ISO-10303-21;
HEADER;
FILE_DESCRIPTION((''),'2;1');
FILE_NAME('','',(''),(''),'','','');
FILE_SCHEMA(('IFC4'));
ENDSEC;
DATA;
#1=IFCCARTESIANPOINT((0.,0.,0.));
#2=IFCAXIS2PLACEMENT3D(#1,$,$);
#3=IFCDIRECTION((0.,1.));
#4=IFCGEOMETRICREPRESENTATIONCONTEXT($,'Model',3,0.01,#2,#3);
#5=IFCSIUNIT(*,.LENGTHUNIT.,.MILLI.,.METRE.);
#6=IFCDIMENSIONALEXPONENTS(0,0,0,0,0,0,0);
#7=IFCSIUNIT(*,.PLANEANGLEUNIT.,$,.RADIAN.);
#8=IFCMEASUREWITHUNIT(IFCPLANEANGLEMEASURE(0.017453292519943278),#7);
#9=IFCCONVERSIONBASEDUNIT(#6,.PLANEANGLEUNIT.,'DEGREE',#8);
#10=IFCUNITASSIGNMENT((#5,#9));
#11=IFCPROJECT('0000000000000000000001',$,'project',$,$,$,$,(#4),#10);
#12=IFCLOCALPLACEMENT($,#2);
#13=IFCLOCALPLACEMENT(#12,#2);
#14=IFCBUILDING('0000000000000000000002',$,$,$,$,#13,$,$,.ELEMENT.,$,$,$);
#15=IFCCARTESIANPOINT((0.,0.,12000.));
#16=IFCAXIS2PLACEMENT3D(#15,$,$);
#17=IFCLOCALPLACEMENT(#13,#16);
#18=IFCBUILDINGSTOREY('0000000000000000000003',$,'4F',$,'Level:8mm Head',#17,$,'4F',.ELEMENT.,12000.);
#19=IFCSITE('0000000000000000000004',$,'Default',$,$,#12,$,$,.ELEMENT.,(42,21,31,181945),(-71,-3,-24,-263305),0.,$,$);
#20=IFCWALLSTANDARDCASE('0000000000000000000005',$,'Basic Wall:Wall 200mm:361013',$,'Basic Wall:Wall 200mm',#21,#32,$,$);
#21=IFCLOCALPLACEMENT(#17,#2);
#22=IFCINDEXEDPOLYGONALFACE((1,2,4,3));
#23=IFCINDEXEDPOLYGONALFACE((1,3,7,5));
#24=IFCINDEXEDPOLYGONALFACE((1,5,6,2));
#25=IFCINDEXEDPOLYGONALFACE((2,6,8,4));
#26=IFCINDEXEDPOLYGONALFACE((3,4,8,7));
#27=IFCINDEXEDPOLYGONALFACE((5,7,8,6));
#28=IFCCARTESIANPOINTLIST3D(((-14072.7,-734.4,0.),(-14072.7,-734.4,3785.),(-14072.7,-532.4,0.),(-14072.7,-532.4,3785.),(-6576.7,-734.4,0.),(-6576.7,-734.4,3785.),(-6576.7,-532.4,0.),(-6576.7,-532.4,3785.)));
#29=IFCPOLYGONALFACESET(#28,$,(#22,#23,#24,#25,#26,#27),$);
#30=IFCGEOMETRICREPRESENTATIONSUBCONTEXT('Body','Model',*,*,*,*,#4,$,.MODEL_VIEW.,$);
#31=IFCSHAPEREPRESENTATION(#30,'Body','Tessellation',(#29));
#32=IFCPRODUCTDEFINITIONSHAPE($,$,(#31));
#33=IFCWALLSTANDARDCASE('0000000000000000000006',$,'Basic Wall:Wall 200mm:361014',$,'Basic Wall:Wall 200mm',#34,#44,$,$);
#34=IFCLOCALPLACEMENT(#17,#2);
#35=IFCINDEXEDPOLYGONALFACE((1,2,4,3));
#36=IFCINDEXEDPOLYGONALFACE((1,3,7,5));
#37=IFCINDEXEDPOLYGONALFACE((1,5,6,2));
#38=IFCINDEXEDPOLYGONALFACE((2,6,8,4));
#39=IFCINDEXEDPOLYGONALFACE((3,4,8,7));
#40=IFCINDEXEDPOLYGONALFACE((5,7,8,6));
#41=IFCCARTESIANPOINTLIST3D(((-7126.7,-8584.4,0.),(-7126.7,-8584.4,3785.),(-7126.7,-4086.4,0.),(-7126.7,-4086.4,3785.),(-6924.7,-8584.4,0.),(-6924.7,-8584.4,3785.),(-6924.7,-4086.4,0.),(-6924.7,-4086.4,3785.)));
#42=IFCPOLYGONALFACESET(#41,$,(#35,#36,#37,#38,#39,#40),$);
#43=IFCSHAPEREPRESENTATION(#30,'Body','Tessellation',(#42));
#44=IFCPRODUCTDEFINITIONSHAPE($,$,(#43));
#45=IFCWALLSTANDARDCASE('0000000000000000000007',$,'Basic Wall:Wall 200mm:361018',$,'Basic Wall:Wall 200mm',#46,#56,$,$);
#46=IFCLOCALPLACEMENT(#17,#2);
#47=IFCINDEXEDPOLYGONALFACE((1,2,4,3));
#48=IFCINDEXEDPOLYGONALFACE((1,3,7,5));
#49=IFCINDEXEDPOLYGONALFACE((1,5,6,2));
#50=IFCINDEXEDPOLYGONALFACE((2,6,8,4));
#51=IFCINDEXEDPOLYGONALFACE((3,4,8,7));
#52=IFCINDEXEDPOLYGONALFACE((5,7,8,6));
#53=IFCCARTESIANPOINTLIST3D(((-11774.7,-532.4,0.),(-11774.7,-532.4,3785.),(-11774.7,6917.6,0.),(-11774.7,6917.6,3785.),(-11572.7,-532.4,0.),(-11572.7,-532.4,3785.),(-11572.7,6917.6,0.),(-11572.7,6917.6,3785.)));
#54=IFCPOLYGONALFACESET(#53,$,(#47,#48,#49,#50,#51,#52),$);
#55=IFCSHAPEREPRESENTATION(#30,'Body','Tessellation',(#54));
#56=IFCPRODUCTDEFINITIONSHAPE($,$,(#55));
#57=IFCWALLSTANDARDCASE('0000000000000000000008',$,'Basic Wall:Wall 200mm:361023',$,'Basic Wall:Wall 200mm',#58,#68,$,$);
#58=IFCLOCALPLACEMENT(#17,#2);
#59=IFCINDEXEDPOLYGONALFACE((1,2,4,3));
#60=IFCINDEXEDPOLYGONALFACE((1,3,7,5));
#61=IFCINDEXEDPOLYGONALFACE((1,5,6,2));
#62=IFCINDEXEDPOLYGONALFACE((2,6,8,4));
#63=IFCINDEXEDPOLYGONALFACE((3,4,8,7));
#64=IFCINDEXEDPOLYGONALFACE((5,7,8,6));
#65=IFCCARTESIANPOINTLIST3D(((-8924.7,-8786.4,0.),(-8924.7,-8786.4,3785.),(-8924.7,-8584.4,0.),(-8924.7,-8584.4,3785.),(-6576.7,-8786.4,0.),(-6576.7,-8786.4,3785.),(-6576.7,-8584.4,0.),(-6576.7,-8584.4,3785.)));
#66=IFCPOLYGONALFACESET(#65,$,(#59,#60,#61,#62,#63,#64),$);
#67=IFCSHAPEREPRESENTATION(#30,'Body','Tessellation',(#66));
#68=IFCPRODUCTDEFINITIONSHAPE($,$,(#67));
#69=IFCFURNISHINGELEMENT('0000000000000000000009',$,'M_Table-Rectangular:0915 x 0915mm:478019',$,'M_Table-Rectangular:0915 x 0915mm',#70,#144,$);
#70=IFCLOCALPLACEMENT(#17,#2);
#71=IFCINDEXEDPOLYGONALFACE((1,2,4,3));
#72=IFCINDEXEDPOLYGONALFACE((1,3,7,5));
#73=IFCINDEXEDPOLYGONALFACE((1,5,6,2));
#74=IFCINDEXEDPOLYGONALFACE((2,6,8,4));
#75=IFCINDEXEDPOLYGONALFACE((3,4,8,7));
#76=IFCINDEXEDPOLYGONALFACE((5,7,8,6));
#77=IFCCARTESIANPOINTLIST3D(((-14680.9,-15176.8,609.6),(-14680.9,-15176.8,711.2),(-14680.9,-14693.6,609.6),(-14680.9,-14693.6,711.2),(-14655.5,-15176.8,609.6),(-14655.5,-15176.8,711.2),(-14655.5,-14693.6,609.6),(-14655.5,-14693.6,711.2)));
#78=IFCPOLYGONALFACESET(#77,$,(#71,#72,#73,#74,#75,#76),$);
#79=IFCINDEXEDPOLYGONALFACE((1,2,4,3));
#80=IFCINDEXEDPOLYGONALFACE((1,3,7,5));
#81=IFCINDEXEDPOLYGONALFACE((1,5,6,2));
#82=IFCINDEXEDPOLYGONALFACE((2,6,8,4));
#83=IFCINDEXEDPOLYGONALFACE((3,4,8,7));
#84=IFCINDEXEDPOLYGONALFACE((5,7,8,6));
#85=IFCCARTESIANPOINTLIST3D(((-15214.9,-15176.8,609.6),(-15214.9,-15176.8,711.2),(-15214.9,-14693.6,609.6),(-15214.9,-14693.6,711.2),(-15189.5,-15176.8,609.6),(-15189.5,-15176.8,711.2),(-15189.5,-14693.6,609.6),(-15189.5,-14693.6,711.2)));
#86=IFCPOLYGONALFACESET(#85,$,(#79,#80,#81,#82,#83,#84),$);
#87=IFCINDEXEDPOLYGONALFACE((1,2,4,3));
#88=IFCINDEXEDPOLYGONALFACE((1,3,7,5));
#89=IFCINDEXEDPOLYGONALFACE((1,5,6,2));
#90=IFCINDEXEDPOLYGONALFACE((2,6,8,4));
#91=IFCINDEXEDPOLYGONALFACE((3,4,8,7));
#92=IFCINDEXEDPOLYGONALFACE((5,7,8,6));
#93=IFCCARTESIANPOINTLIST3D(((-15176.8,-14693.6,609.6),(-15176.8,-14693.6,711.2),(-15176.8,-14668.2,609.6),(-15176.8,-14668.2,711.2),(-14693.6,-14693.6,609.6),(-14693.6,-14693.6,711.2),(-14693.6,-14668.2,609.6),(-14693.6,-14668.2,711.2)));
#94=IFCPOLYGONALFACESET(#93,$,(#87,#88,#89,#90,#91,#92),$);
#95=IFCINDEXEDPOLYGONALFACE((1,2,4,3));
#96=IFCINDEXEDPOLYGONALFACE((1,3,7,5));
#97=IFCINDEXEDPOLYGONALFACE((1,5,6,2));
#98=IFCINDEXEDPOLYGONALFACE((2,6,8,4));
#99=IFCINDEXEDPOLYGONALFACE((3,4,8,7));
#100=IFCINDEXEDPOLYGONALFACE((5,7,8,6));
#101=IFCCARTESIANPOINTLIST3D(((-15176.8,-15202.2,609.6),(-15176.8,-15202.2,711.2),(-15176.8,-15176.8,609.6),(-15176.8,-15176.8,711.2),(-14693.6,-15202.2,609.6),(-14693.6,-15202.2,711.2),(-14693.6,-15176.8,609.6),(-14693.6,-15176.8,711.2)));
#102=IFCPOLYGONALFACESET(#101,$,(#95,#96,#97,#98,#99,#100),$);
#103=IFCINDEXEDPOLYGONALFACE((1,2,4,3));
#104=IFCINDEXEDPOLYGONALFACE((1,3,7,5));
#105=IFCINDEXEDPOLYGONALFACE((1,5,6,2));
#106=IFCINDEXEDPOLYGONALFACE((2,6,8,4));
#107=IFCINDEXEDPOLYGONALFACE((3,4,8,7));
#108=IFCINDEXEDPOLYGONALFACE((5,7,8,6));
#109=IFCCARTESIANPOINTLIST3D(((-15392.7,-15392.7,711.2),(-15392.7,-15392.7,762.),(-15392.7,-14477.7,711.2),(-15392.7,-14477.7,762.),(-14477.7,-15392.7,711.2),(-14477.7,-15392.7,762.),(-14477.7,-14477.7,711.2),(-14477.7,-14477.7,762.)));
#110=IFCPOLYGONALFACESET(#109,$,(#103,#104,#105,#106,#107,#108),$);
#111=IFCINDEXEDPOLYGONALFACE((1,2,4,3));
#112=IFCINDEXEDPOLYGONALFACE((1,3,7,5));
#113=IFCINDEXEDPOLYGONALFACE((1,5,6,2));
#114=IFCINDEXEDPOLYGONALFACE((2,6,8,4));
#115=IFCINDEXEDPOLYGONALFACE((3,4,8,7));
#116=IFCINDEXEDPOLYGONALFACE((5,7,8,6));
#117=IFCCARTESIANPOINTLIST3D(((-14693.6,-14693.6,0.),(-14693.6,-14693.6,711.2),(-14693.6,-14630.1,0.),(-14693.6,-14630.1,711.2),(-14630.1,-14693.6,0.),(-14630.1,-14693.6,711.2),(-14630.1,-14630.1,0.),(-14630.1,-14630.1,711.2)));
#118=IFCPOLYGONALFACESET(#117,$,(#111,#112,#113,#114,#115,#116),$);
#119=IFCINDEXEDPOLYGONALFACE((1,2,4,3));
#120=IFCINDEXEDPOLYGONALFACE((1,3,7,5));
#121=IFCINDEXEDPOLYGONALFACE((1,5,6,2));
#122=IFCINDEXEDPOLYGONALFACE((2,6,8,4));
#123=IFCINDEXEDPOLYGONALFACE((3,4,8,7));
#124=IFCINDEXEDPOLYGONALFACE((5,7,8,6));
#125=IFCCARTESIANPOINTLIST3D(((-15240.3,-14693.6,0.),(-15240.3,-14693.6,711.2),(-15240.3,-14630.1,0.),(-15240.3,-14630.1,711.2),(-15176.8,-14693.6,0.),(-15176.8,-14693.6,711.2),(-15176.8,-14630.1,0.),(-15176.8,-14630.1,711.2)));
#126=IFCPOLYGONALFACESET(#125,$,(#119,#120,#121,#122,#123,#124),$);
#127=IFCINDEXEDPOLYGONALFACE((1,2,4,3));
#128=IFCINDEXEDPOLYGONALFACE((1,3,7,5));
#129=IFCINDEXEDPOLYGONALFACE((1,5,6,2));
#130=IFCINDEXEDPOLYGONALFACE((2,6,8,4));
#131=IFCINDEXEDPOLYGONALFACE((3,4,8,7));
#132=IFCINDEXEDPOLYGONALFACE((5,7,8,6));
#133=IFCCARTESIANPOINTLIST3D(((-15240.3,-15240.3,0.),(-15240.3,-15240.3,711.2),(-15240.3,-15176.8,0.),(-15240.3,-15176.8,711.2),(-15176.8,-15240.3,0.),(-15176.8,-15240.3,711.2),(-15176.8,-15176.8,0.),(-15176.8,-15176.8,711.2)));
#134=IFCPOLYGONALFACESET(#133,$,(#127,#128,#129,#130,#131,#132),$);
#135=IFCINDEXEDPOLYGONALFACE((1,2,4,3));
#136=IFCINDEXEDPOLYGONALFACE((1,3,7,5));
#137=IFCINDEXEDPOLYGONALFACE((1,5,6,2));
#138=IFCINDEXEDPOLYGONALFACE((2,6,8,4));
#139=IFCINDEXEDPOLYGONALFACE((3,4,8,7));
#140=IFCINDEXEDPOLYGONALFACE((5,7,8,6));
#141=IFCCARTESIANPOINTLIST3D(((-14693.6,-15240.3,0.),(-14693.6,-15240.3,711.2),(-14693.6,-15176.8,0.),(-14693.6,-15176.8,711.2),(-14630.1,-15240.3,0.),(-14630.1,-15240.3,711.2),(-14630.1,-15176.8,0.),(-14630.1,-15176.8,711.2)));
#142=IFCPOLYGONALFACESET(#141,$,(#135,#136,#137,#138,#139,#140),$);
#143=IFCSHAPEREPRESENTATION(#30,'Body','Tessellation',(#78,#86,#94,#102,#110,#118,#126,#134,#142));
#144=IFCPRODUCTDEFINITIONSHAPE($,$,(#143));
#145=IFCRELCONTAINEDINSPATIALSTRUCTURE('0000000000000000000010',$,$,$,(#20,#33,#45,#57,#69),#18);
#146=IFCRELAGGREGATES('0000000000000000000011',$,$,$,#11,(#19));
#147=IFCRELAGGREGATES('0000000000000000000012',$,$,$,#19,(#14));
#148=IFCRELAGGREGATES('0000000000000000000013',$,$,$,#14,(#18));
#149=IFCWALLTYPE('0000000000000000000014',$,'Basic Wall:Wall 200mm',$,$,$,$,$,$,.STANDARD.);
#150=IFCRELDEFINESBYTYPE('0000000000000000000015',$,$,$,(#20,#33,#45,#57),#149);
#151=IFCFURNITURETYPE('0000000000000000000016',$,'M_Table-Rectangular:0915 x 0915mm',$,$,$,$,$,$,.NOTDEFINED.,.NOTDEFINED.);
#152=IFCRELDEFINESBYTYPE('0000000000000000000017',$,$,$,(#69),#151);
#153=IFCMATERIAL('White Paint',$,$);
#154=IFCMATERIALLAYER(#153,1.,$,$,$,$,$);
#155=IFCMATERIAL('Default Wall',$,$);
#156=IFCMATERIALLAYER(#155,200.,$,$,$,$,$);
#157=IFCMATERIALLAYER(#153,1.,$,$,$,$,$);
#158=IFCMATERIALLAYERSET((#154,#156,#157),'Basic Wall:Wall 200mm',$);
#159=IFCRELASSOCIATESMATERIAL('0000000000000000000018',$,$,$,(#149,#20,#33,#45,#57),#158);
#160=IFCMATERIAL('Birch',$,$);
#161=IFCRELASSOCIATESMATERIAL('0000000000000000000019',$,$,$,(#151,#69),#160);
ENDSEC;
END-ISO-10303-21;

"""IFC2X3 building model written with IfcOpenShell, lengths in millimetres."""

from ifc_helpers import new_model, entity, si_unit, converted_unit, direction, frame, frame_2d, origin, origin_2d_with_axis, place, context, subcontext, project, spatial, polyline, rectangle, extrude, clip, bounded_halfspace, source, transform, mapped, material, layer, layer_set, layer_usage, type_object, type_shapes, element, save


model = new_model("IFC2X3")

# Units and contexts
model_context = context("Model", 3, precision=0.01, world=origin(), true_north=direction((0.0, 1.0)))
body_context = subcontext(model_context, "Body", "Model", "MODEL_VIEW")
ifc_project = project(units=[si_unit("LENGTHUNIT", "METRE", prefix="MILLI"), converted_unit("PLANEANGLEUNIT", "DEGREE", entity("IfcPlaneAngleMeasure", 0.017453292519943278), si_unit("PLANEANGLEUNIT", "RADIAN"), dimensions=[0, 0, 0, 0, 0, 0, 0])], contexts=[model_context])

# Site, building, storey
site_placement = place(None, origin())
site = spatial("IfcSite", under=ifc_project, at=site_placement, Name="Default", CompositionType="ELEMENT", RefLatitude=(42, 21, 31, 181945), RefLongitude=(-71, -3, -24, -263305), RefElevation=0.0)
building_placement = place(site_placement, origin())
building = spatial("IfcBuilding", under=site, at=building_placement, CompositionType="ELEMENT")
storey_placement = place(building_placement, frame((0.0, 0.0, 12000.0)))
storey = spatial("IfcBuildingStorey", under=building, at=storey_placement, Name="4F", ObjectType="Level:8mm Head", LongName="4F", CompositionType="ELEMENT", Elevation=12000.0)

# Walls
ifc_material_1 = material(Name="White Paint")
ifc_layer_1 = layer(ifc_material_1, 1.0)
ifc_material_2 = material(Name="Default Wall")
ifc_layer_2 = layer(ifc_material_2, 200.0)
ifc_layer_3 = layer(ifc_material_1, 1.0)
ifc_layer_set = layer_set([ifc_layer_1, ifc_layer_2, ifc_layer_3], Name="Basic Wall:Wall 200mm")
wall_type = type_object("IfcWallType", Name="Basic Wall:Wall 200mm", PredefinedType="STANDARD", material=ifc_layer_set)
ifc_layer_usage_1 = layer_usage(ifc_layer_set, "AXIS2", "NEGATIVE", 101.0)
wall_1_placement = place(storey_placement, frame((-14072.7, -633.4, 0.0)))
element("IfcWallStandardCase", 1, at=wall_1_placement, inside=storey, type_object=wall_type, material=ifc_layer_usage_1, Name="Basic Wall:Wall 200mm:361013", ObjectType="Basic Wall:Wall 200mm", context=body_context, shape_type="Clipping", body=[
    clip(extrude(rectangle(XDim=7496.0, YDim=202.0, at=frame_2d((3748.0, 0.0), x_axis=(-1.0, 0.0))), origin(), (0.0, 0.0, 1.0), 3785.0), bounded_halfspace(frame((0.0, -101.0, 3785.0), z_axis=(0.0, 0.0, -1.0), x_axis=(0.0, -1.0, 0.0)), True, frame((0.0, -101.0, 3785.0), z_axis=(0.0, 0.0, -1.0), x_axis=(0.0, -1.0, 0.0)), polyline([(0.0, 0.0), (-202.0, 0.0), (-202.0, -498.0), (-202.0, -2298.0), (-202.0, -2500.0), (-202.0, -6998.0), (-202.0, -7496.0), (0.0, -7496.0), (0.0, -6998.0), (0.0, -498.0), (0.0, 0.0)]))),
])
ifc_layer_usage_2 = layer_usage(ifc_layer_set, "AXIS2", "NEGATIVE", 101.0)
wall_2_placement = place(storey_placement, frame((-7025.7, -4086.4, 0.0), z_axis=(0.0, 0.0, 1.0), x_axis=(0.0, -1.0, 0.0)))
element("IfcWallStandardCase", 2, at=wall_2_placement, inside=storey, type_object=wall_type, material=ifc_layer_usage_2, Name="Basic Wall:Wall 200mm:361014", ObjectType="Basic Wall:Wall 200mm", context=body_context, shape_type="Clipping", body=[
    clip(extrude(rectangle(XDim=4498.0, YDim=202.0, at=frame_2d((2249.0, 0.0), x_axis=(-1.0, 0.0))), origin(), (0.0, 0.0, 1.0), 3785.0), bounded_halfspace(frame((0.0, -101.0, 3785.0), z_axis=(0.0, 0.0, -1.0), x_axis=(1.0, 0.0, 0.0)), True, frame((0.0, -101.0, 3785.0), z_axis=(0.0, 0.0, -1.0), x_axis=(1.0, 0.0, 0.0)), polyline([(0.0, 0.0), (0.0, -202.0), (4498.0, -202.0), (4498.0, 0.0), (4200.0, 0.0), (3998.0, 0.0), (2100.0, 0.0), (1898.0, 0.0), (0.0, 0.0)]))),
])
ifc_layer_usage_3 = layer_usage(ifc_layer_set, "AXIS2", "NEGATIVE", 101.0)
wall_3_placement = place(storey_placement, frame((-11673.7, -532.4, 0.0), z_axis=(0.0, 0.0, 1.0), x_axis=(0.0, 1.0, 0.0)))
element("IfcWallStandardCase", 3, at=wall_3_placement, inside=storey, type_object=wall_type, material=ifc_layer_usage_3, Name="Basic Wall:Wall 200mm:361018", ObjectType="Basic Wall:Wall 200mm", context=body_context, shape_type="Clipping", body=[
    clip(extrude(rectangle(XDim=7450.0, YDim=202.0, at=frame_2d((3725.0, 0.0), x_axis=(-1.0, 0.0))), origin(), (0.0, 0.0, 1.0), 3785.0), bounded_halfspace(frame((0.0, -101.0, 3785.0), z_axis=(0.0, 0.0, -1.0), x_axis=(-1.0, 0.0, 0.0)), True, frame((0.0, -101.0, 3785.0), z_axis=(0.0, 0.0, -1.0), x_axis=(-1.0, 0.0, 0.0)), polyline([(0.0, 0.0), (0.0, 202.0), (-2348.7, 202.0), (-2550.7, 202.0), (-4899.3, 202.0), (-5101.3, 202.0), (-7450.0, 202.0), (-7450.0, 0.0), (-3826.0, 0.0), (-3624.0, 0.0), (0.0, 0.0)]))),
])
ifc_layer_usage_4 = layer_usage(ifc_layer_set, "AXIS2", "NEGATIVE", 101.0)
wall_4_placement = place(storey_placement, frame((-6576.7, -8685.4, 0.0), z_axis=(0.0, 0.0, 1.0), x_axis=(-1.0, 0.0, 0.0)))
element("IfcWallStandardCase", 4, at=wall_4_placement, inside=storey, type_object=wall_type, material=ifc_layer_usage_4, Name="Basic Wall:Wall 200mm:361023", ObjectType="Basic Wall:Wall 200mm", context=body_context, shape_type="Clipping", body=[
    clip(extrude(rectangle(XDim=2348.0, YDim=202.0, at=frame_2d((1174.0, 0.0), x_axis=(-1.0, 0.0))), origin(), (0.0, 0.0, 1.0), 3785.0), bounded_halfspace(frame((0.0, -101.0, 3785.0), z_axis=(0.0, 0.0, -1.0), x_axis=(0.0, 1.0, 0.0)), True, frame((0.0, -101.0, 3785.0), z_axis=(0.0, 0.0, -1.0), x_axis=(0.0, 1.0, 0.0)), polyline([(0.0, 0.0), (202.0, 0.0), (202.0, 2348.0), (0.0, 2348.0), (0.0, 550.0), (0.0, 348.0), (0.0, 0.0)]))),
])

# Furnishing element
ifc_material_3 = material(Name="Birch")
furniture_type = type_object("IfcFurnitureType", Name="M_Table-Rectangular:0915 x 0915mm", AssemblyPlace="NOTDEFINED", material=ifc_material_3)
shared_shape_1 = source(origin(), body_context, "Body", "SweptSolid", [
    extrude(rectangle(XDim=25.4, YDim=483.2, at=origin_2d_with_axis()), frame((267.0, 0.0, 609.6)), (0.0, 0.0, 1.0), 101.6),
    extrude(rectangle(XDim=483.2, YDim=25.4, at=origin_2d_with_axis()), frame((-267.0, 0.0, 609.6), z_axis=(0.0, 0.0, 1.0), x_axis=(0.0, 1.0, 0.0)), (0.0, 0.0, 1.0), 101.6),
    extrude(rectangle(XDim=483.2, YDim=25.4, at=frame_2d((0.0, 0.0), x_axis=(1.0, 0.0))), frame((0.0, 254.3, 609.6), z_axis=(0.0, 0.0, 1.0), x_axis=(-1.0, 0.0, 0.0)), (0.0, 0.0, 1.0), 101.6),
    extrude(rectangle(XDim=25.4, YDim=483.2, at=origin_2d_with_axis()), frame((0.0, -254.3, 609.6), z_axis=(0.0, 0.0, 1.0), x_axis=(0.0, 1.0, 0.0)), (0.0, 0.0, 1.0), 101.6),
    extrude(rectangle(XDim=915.0, YDim=915.0, at=origin_2d_with_axis()), frame((0.0, 0.0, 711.2), z_axis=(0.0, 0.0, 1.0), x_axis=(-1.0, 0.0, 0.0)), (0.0, 0.0, 1.0), 50.8),
    extrude(rectangle(XDim=63.5, YDim=63.5, at=origin_2d_with_axis()), frame((273.3, 273.4, 0.0), z_axis=(0.0, 0.0, 1.0), x_axis=(0.0, -1.0, 0.0)), (0.0, 0.0, 1.0), 711.2),
    extrude(rectangle(XDim=63.5, YDim=63.5, at=origin_2d_with_axis()), frame((-273.3, 273.4, 0.0), z_axis=(0.0, 0.0, 1.0), x_axis=(-1.0, 0.0, 0.0)), (0.0, 0.0, 1.0), 711.2),
    extrude(rectangle(XDim=63.5, YDim=63.5, at=origin_2d_with_axis()), frame((-273.3, -273.4, 0.0), z_axis=(0.0, 0.0, 1.0), x_axis=(0.0, 1.0, 0.0)), (0.0, 0.0, 1.0), 711.2),
    extrude(rectangle(XDim=63.5, YDim=63.5, at=origin_2d_with_axis()), frame((273.3, -273.4, 0.0)), (0.0, 0.0, 1.0), 711.2),
])
type_shapes(furniture_type, [shared_shape_1])
for number, where, name in (
    (5, (-14935.2, -14935.2, 0.0), "M_Table-Rectangular:0915 x 0915mm:478019"),
):
    element("IfcFurnishingElement", number, at=place(storey_placement, frame(where)), inside=storey, type_object=furniture_type, material=ifc_material_3, Name=name, ObjectType="M_Table-Rectangular:0915 x 0915mm", context=body_context, shape_type="MappedRepresentation", body=[
        mapped(shared_shape_1, transform((0.0, 0.0, 0.0), scale=1.0)),
    ])

save(model, "model.ifc")
